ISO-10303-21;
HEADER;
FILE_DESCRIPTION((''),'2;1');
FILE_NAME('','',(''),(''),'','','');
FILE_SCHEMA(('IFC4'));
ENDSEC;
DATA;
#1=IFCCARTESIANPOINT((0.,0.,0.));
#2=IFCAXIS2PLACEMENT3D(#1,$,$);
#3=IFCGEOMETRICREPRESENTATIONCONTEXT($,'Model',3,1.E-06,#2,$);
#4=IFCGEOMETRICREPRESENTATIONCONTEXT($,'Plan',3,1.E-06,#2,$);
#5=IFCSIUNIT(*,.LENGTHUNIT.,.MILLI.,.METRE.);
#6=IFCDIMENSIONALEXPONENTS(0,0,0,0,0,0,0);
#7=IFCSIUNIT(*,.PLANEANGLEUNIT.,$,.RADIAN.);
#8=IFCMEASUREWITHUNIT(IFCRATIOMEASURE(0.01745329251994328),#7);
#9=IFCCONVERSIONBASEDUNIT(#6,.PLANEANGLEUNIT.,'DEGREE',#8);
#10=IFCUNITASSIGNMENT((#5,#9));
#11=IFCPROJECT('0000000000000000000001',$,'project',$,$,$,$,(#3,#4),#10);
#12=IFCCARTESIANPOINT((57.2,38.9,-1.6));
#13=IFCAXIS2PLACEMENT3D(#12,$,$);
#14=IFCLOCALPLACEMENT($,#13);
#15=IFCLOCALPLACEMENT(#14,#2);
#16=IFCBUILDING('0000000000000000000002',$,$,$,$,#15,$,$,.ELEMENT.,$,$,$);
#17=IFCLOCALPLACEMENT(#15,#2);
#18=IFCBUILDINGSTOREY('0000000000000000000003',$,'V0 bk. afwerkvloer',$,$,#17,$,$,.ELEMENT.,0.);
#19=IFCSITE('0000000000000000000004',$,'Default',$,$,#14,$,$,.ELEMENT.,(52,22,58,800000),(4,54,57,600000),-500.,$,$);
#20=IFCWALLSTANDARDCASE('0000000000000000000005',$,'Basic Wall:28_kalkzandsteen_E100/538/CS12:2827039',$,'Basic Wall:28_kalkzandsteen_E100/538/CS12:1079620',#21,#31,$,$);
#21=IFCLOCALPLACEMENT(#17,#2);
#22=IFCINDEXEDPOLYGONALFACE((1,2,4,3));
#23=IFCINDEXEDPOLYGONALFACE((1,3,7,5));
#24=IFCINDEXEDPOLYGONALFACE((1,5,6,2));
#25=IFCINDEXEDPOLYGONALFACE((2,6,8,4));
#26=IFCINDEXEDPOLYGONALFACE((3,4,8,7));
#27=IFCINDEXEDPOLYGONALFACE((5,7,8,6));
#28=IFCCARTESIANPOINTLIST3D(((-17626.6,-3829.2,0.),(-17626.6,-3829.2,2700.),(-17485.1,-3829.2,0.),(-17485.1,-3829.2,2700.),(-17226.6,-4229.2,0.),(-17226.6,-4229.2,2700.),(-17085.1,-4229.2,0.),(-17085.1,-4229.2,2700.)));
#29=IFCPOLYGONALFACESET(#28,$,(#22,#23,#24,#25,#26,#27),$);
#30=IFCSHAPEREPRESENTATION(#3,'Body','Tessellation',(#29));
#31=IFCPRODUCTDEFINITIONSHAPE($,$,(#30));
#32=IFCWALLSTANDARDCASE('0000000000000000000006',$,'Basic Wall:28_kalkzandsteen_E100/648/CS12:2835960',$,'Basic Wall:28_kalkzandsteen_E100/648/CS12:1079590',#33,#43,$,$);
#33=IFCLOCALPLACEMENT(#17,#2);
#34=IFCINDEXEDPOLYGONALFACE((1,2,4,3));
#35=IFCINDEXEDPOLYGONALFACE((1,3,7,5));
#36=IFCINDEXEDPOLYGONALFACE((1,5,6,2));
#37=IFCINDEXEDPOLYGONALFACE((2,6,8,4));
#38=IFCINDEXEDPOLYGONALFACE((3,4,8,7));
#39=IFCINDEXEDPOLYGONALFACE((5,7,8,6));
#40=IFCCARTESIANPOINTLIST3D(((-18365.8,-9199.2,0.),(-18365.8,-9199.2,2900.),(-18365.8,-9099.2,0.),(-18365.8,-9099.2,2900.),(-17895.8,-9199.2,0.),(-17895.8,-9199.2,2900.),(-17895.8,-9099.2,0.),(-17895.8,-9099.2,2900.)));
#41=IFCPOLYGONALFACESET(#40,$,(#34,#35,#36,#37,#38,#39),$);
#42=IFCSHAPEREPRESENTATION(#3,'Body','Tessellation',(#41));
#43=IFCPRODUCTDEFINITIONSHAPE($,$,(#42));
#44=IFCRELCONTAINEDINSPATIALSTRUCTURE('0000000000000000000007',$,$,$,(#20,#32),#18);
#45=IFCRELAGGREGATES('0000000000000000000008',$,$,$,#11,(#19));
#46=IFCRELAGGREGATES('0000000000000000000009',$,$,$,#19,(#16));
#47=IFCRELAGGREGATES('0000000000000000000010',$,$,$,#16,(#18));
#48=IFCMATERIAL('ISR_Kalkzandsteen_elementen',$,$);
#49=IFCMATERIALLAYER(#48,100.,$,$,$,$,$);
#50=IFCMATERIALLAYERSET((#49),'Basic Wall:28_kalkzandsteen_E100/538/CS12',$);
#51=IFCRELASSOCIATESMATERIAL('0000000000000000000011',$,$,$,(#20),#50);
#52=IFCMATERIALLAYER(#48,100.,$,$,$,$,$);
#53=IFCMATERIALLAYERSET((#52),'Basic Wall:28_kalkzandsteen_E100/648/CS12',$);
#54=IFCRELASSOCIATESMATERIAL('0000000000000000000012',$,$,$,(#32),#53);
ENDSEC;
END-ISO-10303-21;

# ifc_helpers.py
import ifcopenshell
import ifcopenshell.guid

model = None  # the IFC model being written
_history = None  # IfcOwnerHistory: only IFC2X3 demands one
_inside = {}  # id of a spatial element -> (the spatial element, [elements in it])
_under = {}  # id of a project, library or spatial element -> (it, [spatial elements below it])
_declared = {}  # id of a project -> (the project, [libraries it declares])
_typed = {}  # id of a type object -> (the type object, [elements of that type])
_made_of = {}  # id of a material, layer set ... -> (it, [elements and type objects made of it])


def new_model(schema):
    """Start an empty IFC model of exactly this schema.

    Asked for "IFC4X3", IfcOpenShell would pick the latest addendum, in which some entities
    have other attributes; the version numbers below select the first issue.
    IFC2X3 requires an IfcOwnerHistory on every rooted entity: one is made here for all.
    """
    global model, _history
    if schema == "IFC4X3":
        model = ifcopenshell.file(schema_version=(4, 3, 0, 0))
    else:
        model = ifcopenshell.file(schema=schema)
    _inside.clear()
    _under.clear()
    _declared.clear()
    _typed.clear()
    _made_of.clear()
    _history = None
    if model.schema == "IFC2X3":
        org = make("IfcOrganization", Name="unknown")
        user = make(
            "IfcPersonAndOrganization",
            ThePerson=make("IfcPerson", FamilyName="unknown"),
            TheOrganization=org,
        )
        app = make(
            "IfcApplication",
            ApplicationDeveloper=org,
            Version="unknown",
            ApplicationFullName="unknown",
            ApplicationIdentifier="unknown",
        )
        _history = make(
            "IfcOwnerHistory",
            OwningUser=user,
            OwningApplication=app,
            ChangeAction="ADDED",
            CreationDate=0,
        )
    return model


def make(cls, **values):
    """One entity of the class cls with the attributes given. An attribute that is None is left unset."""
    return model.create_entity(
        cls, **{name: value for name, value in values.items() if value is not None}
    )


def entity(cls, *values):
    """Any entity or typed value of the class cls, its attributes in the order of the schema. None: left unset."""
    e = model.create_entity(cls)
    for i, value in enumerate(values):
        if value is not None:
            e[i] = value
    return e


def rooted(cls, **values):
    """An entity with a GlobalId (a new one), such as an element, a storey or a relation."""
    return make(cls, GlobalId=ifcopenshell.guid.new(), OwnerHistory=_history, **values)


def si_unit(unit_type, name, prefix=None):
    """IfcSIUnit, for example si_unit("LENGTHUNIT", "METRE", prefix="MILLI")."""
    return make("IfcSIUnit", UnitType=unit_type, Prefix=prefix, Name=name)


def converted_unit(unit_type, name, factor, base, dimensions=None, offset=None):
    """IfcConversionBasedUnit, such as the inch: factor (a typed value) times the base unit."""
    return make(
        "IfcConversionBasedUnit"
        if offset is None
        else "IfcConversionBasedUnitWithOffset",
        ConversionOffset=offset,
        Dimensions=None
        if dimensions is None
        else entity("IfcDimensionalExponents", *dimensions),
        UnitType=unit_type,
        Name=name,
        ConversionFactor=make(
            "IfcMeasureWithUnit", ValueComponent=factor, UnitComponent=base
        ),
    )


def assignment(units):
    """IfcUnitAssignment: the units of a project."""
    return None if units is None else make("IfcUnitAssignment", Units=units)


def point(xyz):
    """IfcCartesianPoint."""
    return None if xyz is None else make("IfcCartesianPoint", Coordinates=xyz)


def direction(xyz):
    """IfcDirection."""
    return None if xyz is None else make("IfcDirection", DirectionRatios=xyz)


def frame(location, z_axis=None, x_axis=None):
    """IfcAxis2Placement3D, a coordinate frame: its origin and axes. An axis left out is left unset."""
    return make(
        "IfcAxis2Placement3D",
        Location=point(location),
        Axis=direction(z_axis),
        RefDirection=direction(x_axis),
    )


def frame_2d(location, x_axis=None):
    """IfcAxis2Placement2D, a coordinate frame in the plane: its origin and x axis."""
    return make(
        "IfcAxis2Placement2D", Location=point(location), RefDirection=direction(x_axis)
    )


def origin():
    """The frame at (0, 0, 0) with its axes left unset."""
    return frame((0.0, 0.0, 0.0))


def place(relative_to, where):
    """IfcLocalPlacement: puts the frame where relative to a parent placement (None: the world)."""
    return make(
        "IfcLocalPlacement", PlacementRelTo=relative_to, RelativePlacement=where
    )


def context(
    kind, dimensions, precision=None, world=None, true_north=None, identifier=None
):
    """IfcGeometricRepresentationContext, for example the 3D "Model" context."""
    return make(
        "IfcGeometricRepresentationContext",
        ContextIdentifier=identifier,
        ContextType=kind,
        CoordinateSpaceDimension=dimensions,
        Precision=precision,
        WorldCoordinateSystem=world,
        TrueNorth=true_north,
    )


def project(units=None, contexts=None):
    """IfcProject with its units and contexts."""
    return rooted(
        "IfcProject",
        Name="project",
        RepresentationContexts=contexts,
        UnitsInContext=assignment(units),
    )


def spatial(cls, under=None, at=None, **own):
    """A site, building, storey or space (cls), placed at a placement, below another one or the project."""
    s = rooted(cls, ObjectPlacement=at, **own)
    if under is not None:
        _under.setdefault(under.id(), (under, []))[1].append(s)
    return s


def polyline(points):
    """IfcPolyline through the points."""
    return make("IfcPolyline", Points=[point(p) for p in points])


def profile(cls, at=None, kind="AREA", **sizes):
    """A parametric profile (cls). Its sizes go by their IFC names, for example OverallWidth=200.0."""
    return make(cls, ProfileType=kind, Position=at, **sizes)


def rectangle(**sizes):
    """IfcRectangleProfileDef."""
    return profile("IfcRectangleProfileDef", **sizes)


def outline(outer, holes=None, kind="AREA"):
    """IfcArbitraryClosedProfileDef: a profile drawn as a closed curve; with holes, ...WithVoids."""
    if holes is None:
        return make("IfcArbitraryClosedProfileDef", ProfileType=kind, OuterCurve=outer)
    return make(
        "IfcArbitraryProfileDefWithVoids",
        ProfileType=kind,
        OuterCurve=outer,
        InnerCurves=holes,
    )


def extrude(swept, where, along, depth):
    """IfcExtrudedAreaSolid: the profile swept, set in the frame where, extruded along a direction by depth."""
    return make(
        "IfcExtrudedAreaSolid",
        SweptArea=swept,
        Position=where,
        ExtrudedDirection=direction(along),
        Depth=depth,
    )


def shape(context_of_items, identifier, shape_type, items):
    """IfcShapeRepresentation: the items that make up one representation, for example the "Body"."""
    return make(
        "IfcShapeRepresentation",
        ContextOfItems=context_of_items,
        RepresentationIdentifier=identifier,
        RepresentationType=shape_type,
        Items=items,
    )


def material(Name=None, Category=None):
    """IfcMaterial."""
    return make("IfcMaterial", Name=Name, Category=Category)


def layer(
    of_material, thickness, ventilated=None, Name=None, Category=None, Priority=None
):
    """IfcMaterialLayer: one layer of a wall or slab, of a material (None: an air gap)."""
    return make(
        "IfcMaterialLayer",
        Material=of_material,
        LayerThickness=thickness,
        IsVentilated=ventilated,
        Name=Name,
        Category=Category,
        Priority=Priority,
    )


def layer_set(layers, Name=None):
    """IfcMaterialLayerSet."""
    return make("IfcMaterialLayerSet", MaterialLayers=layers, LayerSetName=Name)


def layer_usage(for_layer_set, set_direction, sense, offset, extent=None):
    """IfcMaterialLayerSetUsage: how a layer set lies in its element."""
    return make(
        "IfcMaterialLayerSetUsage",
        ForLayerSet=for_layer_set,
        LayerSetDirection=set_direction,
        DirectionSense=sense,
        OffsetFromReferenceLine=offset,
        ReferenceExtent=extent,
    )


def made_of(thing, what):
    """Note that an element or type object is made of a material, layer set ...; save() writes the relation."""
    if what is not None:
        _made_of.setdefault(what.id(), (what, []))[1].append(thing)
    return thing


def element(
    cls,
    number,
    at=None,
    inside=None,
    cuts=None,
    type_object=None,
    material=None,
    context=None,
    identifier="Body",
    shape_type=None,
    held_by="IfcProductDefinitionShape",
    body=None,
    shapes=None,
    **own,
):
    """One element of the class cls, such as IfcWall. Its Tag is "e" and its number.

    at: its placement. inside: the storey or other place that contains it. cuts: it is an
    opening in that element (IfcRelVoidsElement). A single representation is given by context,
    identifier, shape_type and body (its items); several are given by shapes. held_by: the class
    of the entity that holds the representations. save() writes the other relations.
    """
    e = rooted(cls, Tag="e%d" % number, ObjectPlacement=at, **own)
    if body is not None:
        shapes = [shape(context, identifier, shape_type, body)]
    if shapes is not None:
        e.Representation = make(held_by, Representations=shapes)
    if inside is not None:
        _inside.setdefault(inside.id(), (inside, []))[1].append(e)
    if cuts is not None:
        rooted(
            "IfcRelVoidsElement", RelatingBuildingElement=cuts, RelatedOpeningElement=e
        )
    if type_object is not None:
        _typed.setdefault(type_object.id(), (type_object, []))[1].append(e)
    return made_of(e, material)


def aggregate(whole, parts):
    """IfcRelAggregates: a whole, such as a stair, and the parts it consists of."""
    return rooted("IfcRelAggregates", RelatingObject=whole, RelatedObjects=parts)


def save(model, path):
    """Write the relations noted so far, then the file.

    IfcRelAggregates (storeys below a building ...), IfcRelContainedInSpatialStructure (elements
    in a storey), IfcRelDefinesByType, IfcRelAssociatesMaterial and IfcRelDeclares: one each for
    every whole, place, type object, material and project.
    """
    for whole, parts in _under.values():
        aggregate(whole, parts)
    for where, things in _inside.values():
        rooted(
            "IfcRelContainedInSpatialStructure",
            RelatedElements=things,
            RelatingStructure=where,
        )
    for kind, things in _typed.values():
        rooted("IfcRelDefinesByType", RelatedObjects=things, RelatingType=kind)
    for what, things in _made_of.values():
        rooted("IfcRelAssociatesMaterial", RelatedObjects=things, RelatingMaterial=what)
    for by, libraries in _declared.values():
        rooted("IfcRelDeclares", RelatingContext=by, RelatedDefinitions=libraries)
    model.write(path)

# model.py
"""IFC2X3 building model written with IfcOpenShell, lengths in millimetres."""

from ifc_helpers import new_model, entity, si_unit, converted_unit, frame, frame_2d, origin, place, context, project, spatial, polyline, rectangle, outline, extrude, material, layer, layer_set, layer_usage, element, save


model = new_model("IFC2X3")

# Units and contexts
model_context = context("Model", 3, precision=1e-06, world=origin())
plan_context = context("Plan", 3, precision=1e-06, world=origin())
ifc_project = project(units=[si_unit("LENGTHUNIT", "METRE", prefix="MILLI"), converted_unit("PLANEANGLEUNIT", "DEGREE", entity("IfcRatioMeasure", 0.01745329251994328), si_unit("PLANEANGLEUNIT", "RADIAN"), dimensions=[0, 0, 0, 0, 0, 0, 0])], contexts=[model_context, plan_context])

# Site, building, storey
site_placement = place(None, frame((57.2, 38.9, -1.6)))
site = spatial("IfcSite", under=ifc_project, at=site_placement, Name="Default", CompositionType="ELEMENT", RefLatitude=(52, 22, 58, 800000), RefLongitude=(4, 54, 57, 600000), RefElevation=-500.0)
building_placement = place(site_placement, origin())
building = spatial("IfcBuilding", under=site, at=building_placement, CompositionType="ELEMENT")
storey_placement = place(building_placement, origin())
storey = spatial("IfcBuildingStorey", under=building, at=storey_placement, Name="V0 bk. afwerkvloer", CompositionType="ELEMENT", Elevation=0.0)

# Shared definitions
ifc_material_1 = material(Name="ISR_Kalkzandsteen_elementen")
ifc_layer_1 = layer(ifc_material_1, 100.0)
ifc_layer_set_1 = layer_set([ifc_layer_1], Name="Basic Wall:28_kalkzandsteen_E100/538/CS12")

# Wall
ifc_layer_usage_1 = layer_usage(ifc_layer_set_1, "AXIS2", "NEGATIVE", 50.0)
wall_1_placement = place(storey_placement, frame((-17120.5, -4264.6, 0.0), z_axis=(0.0, 0.0, 1.0), x_axis=(-0.707107, 0.707107, 0.0)))
element("IfcWallStandardCase", 1, at=wall_1_placement, inside=storey, material=ifc_layer_usage_1, Name="Basic Wall:28_kalkzandsteen_E100/538/CS12:2827039", ObjectType="Basic Wall:28_kalkzandsteen_E100/538/CS12:1079620", context=model_context, shape_type="SweptSolid", body=[
    extrude(outline(polyline([(565.7, -50.0), (665.7, 50.0), (100.0, 50.0), (0.0, -50.0), (565.7, -50.0)])), origin(), (0.0, 0.0, 1.0), 2700.0),
])

# Wall
ifc_layer_2 = layer(ifc_material_1, 100.0)
ifc_layer_set_2 = layer_set([ifc_layer_2], Name="Basic Wall:28_kalkzandsteen_E100/648/CS12")
ifc_layer_usage_2 = layer_usage(ifc_layer_set_2, "AXIS2", "POSITIVE", -50.0)
wall_2_placement = place(storey_placement, frame((-18365.8, -9149.2, 0.0)))
element("IfcWallStandardCase", 2, at=wall_2_placement, inside=storey, material=ifc_layer_usage_2, Name="Basic Wall:28_kalkzandsteen_E100/648/CS12:2835960", ObjectType="Basic Wall:28_kalkzandsteen_E100/648/CS12:1079590", context=model_context, shape_type="SweptSolid", body=[
    extrude(rectangle(XDim=470.0, YDim=100.0, at=frame_2d((235.0, 0.0), x_axis=(-1.0, 0.0))), origin(), (0.0, 0.0, 1.0), 2900.0),
])

save(model, "model.ifc")
